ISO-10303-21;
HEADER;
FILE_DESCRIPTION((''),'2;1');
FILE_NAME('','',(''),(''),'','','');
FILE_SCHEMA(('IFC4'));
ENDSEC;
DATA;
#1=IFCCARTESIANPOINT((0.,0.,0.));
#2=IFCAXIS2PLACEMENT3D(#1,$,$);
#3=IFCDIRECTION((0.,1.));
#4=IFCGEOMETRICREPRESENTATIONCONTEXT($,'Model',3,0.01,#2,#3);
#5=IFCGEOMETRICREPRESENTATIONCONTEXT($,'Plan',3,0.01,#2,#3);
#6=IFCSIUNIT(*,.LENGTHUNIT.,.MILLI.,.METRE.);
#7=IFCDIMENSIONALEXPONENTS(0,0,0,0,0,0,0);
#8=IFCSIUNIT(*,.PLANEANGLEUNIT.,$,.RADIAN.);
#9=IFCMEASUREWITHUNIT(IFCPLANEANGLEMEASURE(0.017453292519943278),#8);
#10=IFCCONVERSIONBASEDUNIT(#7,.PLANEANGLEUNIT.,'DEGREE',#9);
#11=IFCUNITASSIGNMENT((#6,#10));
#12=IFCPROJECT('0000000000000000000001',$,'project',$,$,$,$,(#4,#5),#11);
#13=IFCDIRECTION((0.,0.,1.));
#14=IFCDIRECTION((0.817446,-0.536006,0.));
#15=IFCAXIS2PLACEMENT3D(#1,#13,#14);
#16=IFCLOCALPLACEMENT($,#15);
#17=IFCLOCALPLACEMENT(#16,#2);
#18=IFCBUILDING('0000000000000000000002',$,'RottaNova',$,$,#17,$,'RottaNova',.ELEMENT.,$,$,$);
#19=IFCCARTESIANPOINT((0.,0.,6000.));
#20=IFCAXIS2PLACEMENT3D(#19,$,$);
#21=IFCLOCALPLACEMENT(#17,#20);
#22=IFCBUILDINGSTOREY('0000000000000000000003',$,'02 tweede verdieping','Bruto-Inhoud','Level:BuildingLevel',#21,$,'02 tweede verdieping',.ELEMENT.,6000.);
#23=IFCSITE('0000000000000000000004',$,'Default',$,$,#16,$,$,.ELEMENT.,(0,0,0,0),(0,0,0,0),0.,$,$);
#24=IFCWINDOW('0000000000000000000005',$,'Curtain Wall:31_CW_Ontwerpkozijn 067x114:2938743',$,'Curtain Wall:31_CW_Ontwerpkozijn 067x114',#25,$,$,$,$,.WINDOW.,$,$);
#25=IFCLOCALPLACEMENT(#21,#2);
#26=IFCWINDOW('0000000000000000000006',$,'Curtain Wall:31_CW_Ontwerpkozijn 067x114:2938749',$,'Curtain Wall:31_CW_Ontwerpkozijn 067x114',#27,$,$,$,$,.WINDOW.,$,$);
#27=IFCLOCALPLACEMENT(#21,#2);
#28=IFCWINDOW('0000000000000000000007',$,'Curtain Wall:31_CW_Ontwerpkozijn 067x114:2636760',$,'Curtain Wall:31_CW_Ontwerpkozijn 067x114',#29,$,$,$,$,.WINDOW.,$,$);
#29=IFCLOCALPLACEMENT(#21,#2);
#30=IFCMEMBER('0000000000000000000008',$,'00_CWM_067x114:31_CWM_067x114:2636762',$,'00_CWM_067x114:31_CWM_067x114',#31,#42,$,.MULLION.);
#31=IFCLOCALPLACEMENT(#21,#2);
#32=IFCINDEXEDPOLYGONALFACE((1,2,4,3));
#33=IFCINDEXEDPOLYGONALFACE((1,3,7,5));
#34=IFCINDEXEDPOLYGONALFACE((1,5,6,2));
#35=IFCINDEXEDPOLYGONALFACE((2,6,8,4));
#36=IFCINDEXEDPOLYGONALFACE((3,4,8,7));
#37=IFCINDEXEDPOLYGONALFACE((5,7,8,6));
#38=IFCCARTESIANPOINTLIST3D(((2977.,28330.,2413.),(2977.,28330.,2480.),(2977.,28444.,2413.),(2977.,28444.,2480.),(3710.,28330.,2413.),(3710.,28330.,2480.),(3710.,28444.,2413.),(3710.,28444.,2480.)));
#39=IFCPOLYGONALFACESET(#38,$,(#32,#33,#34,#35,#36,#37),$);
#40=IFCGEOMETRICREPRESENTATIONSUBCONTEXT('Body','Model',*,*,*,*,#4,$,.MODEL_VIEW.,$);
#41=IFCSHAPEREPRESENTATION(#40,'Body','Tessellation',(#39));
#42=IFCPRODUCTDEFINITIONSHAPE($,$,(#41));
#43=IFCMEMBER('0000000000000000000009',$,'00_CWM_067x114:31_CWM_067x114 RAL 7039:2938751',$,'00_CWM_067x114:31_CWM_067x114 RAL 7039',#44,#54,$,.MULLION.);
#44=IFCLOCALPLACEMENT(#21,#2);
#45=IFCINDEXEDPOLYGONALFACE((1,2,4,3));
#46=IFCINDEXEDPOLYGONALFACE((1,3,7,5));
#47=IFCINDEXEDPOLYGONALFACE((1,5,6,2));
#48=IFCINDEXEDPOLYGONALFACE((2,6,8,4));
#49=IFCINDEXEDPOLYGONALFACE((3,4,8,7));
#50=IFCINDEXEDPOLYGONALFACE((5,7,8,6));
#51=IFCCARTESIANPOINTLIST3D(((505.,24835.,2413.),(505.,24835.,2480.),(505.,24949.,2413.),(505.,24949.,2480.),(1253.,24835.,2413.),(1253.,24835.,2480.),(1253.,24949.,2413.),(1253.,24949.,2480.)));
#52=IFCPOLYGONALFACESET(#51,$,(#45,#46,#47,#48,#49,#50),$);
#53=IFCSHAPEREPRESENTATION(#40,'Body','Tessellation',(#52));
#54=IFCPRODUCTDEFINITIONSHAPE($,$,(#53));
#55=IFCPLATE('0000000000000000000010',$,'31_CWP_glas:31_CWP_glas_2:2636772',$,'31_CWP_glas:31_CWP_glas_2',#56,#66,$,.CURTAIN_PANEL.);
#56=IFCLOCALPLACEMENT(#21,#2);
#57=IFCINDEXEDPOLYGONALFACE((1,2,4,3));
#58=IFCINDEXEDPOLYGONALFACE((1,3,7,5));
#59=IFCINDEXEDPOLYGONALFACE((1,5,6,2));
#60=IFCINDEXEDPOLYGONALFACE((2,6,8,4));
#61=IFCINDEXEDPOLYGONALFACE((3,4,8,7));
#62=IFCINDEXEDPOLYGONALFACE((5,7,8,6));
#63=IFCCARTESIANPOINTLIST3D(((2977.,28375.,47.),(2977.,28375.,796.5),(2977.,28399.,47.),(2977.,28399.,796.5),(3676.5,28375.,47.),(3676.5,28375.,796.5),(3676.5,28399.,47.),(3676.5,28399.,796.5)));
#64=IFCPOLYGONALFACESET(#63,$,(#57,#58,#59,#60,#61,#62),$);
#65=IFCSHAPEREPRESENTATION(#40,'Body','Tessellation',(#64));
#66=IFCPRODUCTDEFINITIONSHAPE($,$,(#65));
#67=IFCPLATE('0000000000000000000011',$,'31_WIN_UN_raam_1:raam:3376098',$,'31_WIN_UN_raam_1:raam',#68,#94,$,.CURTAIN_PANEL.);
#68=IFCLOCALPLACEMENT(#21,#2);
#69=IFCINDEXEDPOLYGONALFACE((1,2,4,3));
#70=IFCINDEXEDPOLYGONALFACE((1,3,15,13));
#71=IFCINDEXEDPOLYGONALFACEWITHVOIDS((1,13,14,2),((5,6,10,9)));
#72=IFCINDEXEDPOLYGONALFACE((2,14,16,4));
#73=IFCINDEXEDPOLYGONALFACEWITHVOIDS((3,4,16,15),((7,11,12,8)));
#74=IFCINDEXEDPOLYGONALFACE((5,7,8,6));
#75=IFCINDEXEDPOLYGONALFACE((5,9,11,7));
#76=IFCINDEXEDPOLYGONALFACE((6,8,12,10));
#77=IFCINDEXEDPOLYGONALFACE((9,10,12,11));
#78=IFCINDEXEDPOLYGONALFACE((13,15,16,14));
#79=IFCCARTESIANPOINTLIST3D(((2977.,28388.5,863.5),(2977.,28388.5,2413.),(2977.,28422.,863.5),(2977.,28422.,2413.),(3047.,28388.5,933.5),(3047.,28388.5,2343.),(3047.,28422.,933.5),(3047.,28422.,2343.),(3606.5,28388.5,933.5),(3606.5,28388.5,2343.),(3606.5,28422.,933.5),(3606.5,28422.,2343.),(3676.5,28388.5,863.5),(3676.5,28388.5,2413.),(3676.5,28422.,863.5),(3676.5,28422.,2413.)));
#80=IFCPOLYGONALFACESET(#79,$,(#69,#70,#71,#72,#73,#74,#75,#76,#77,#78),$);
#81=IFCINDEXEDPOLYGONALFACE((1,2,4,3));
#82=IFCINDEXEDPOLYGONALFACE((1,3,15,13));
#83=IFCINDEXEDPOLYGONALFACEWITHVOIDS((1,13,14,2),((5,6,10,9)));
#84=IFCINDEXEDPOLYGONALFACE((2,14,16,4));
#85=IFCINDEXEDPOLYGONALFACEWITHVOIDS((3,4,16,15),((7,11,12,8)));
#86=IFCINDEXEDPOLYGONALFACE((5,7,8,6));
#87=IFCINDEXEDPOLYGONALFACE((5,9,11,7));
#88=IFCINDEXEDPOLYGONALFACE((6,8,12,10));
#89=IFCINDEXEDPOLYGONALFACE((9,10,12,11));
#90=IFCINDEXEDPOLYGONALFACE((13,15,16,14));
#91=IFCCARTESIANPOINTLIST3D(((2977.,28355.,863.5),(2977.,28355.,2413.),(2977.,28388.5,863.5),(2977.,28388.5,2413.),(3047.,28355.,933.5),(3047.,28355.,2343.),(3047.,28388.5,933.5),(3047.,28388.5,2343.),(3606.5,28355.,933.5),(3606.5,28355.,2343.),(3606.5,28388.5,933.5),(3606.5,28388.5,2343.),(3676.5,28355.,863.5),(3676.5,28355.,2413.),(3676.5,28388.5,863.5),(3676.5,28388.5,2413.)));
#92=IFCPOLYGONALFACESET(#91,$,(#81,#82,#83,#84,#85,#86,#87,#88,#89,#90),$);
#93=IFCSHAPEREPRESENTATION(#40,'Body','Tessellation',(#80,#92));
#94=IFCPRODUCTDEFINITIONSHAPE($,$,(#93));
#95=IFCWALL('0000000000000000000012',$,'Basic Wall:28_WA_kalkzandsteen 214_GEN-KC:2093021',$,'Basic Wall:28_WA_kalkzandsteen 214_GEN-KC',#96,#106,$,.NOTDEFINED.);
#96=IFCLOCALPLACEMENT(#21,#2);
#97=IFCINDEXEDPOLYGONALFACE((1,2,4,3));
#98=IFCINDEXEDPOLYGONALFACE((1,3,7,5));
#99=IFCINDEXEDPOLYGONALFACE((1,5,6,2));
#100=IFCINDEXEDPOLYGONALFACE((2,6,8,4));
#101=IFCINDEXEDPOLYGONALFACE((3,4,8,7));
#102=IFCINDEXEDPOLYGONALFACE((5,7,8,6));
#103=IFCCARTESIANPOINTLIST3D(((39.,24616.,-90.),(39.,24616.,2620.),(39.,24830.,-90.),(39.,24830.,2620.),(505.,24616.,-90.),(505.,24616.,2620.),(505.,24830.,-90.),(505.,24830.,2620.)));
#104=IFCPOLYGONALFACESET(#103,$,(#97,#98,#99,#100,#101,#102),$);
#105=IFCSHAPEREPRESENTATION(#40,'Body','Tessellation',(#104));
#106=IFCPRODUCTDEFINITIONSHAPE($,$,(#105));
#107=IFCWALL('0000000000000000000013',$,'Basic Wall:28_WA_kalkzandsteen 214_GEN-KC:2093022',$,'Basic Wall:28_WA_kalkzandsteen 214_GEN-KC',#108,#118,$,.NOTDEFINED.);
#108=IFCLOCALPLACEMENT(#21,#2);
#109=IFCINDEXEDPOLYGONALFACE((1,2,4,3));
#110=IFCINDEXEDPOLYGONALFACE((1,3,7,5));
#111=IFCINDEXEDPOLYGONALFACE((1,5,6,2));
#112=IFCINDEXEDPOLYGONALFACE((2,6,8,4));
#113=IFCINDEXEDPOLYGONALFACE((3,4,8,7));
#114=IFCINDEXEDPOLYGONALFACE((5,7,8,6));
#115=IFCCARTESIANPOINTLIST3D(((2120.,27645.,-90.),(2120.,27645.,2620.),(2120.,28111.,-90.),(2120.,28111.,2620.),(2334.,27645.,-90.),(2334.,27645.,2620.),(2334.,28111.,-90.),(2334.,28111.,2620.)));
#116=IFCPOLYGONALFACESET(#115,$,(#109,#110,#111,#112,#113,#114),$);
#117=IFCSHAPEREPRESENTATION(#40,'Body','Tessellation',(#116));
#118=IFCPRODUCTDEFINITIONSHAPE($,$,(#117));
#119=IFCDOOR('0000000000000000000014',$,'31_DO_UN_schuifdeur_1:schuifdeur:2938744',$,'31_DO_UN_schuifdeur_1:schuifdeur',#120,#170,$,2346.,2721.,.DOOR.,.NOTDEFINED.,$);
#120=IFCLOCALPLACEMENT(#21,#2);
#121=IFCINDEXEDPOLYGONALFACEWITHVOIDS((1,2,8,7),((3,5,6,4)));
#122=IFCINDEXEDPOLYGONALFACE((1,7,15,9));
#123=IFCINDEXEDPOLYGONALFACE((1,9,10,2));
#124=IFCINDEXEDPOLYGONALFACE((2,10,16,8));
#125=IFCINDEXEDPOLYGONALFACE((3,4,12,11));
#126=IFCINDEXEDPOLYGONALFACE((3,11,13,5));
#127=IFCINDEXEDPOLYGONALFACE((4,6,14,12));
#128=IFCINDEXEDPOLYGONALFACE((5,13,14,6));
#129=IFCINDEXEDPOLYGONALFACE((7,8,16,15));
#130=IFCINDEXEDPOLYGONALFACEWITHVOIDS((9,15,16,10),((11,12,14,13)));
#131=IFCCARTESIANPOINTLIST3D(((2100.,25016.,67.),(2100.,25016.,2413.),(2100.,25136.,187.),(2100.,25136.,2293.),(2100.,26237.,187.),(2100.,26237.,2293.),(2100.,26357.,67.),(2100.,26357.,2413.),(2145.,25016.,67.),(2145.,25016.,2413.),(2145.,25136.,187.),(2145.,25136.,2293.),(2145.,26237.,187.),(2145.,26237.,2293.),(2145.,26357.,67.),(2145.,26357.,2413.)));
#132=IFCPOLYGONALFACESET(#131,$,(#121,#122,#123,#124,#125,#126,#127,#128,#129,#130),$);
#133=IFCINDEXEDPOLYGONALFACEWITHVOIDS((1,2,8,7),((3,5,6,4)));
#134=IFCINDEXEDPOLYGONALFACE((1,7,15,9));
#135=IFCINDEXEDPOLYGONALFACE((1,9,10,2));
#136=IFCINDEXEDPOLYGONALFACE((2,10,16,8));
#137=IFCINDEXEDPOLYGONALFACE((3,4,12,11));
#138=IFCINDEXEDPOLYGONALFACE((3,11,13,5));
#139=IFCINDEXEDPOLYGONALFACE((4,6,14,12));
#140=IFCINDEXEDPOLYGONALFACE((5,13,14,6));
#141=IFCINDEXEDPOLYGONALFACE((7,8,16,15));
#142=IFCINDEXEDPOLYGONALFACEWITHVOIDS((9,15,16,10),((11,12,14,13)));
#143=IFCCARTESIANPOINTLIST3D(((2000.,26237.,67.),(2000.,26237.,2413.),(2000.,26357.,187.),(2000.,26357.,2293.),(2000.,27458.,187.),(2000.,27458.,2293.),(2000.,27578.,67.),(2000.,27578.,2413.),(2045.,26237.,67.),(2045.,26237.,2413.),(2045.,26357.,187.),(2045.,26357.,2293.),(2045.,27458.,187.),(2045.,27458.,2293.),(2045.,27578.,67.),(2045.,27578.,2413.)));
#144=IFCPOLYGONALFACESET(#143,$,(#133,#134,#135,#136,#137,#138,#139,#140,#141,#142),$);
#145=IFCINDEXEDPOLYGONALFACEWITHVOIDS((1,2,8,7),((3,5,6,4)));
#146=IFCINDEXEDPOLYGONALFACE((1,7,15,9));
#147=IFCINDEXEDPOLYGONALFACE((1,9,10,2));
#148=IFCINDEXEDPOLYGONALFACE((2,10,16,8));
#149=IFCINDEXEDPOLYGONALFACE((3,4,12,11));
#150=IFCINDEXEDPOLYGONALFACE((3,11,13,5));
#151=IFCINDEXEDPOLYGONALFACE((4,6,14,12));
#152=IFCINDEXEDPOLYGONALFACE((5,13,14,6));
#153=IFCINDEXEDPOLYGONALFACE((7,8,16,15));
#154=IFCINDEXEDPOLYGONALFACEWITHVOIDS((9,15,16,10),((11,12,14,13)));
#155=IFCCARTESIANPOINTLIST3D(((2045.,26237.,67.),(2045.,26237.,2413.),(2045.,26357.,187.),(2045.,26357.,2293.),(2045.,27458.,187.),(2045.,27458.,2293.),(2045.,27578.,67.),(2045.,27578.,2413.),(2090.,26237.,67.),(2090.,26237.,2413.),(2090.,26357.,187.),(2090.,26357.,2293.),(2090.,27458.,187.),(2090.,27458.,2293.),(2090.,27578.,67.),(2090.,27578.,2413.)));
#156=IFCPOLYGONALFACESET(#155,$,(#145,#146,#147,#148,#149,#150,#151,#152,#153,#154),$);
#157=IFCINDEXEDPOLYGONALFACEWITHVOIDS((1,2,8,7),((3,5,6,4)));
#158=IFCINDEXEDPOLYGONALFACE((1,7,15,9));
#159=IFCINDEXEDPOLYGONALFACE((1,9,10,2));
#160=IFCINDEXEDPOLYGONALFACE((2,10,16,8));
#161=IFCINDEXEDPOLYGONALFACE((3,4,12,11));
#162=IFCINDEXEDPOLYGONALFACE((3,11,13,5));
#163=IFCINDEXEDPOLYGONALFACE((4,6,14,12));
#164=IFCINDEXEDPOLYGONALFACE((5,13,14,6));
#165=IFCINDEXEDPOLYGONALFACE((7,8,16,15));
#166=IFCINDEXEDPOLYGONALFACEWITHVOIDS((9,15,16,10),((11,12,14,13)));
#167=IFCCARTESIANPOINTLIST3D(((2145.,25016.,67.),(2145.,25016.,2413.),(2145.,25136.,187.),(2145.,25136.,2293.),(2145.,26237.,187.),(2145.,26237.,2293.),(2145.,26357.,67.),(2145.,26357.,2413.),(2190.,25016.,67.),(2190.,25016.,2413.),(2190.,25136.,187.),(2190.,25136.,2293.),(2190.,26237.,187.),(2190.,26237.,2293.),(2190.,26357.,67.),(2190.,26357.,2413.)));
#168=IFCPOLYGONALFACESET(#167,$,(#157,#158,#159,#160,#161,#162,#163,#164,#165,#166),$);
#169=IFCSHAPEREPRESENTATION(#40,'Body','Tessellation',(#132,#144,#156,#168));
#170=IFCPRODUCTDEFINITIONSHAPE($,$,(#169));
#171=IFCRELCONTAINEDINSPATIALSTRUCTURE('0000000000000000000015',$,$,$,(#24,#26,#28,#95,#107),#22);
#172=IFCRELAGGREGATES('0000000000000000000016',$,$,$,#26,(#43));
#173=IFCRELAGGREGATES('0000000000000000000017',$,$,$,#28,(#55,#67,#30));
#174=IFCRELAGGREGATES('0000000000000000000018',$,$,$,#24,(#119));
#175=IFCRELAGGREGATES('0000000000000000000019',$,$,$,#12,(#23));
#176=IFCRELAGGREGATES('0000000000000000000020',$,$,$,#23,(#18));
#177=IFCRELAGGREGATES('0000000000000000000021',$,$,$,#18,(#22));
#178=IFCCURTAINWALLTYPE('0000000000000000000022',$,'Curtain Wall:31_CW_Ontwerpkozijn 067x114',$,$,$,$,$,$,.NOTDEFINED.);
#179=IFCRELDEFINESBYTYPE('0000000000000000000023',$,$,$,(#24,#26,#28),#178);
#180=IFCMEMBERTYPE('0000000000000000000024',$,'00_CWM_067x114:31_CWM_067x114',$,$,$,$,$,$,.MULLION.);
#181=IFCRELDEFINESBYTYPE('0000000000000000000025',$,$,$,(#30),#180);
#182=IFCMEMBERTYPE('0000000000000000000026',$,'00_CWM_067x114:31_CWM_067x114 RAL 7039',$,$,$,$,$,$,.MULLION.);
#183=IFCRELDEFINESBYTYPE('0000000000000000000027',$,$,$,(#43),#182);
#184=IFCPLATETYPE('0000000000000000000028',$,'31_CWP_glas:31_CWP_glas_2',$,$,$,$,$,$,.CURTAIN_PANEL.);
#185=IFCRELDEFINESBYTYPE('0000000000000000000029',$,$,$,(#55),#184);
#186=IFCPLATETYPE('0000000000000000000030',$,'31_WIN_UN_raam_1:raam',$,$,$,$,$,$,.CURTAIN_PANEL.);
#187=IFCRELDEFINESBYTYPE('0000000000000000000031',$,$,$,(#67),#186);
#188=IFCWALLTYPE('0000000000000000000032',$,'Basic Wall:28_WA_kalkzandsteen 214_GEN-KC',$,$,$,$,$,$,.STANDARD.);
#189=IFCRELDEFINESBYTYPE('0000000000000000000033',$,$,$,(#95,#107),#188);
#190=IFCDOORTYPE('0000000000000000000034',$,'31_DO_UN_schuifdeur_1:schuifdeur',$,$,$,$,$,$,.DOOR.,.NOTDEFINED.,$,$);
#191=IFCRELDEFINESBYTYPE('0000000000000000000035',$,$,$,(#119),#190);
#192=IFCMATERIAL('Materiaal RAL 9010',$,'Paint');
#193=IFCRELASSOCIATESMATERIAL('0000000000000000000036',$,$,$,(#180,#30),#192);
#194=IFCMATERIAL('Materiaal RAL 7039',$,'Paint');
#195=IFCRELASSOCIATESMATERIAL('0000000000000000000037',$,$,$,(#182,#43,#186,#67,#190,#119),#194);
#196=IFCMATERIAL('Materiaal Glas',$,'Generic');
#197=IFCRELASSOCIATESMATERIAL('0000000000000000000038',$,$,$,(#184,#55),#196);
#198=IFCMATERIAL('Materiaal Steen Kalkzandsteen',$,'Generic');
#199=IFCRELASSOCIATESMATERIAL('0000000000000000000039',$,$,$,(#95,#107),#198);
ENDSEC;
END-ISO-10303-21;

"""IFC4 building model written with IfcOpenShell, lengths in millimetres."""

from ifc_helpers import new_model, entity, si_unit, converted_unit, direction, frame, origin, place, context, subcontext, project, spatial, indexed_curve, outline, extrude, source, transform, mapped, material, type_object, type_shapes, element, aggregate, save


model = new_model("IFC4")

# Units and contexts
model_context = context("Model", 3, precision=0.01, world=origin(), true_north=direction((0.0, 1.0)))
plan_context = context("Plan", 3, precision=0.01, world=origin(), true_north=direction((0.0, 1.0)))
body_context = subcontext(model_context, "Body", "Model", "MODEL_VIEW")
ifc_project = project(units=[si_unit("LENGTHUNIT", "METRE", prefix="MILLI"), converted_unit("PLANEANGLEUNIT", "DEGREE", entity("IfcPlaneAngleMeasure", 0.017453292519943278), si_unit("PLANEANGLEUNIT", "RADIAN"), dimensions=[0, 0, 0, 0, 0, 0, 0])], contexts=[model_context, plan_context])

# Site, building, storey
site_placement = place(None, frame((0.0, 0.0, 0.0), z_axis=(0.0, 0.0, 1.0), x_axis=(0.817446, -0.536006, 0.0)))
site = spatial("IfcSite", under=ifc_project, at=site_placement, Name="Default", CompositionType="ELEMENT", RefLatitude=(0, 0, 0, 0), RefLongitude=(0, 0, 0, 0), RefElevation=0.0)
building_placement = place(site_placement, origin())
building = spatial("IfcBuilding", under=site, at=building_placement, Name="RottaNova", LongName="RottaNova", CompositionType="ELEMENT")
storey_placement = place(building_placement, frame((0.0, 0.0, 6000.0)))
storey = spatial("IfcBuildingStorey", under=building, at=storey_placement, Name="02 tweede verdieping", Description="Bruto-Inhoud", ObjectType="Level:BuildingLevel", LongName="02 tweede verdieping", CompositionType="ELEMENT", Elevation=6000.0)

# Window
curtain_wall_type = type_object("IfcCurtainWallType", Name="Curtain Wall:31_CW_Ontwerpkozijn 067x114", PredefinedType="NOTDEFINED")
window_1_placement = place(storey_placement, frame((0.0, 0.0, -6000.0)))
window_1 = element("IfcWindow", 1, at=window_1_placement, inside=storey, type_object=curtain_wall_type, Name="Curtain Wall:31_CW_Ontwerpkozijn 067x114:2938743", ObjectType="Curtain Wall:31_CW_Ontwerpkozijn 067x114", PredefinedType="WINDOW")
ifc_material_1 = material(Name="Materiaal RAL 7039", Category="Paint")

# Window
window_2_placement = place(storey_placement, frame((0.0, 0.0, -6000.0)))
window_2 = element("IfcWindow", 2, at=window_2_placement, inside=storey, type_object=curtain_wall_type, Name="Curtain Wall:31_CW_Ontwerpkozijn 067x114:2938749", ObjectType="Curtain Wall:31_CW_Ontwerpkozijn 067x114", PredefinedType="WINDOW")

# Window, member
window_3_placement = place(storey_placement, frame((0.0, 0.0, -6000.0)))
window_3 = element("IfcWindow", 3, at=window_3_placement, inside=storey, type_object=curtain_wall_type, Name="Curtain Wall:31_CW_Ontwerpkozijn 067x114:2636760", ObjectType="Curtain Wall:31_CW_Ontwerpkozijn 067x114", PredefinedType="WINDOW")
ifc_material_2 = material(Name="Materiaal RAL 9010", Category="Paint")
member_type_1 = type_object("IfcMemberType", Name="00_CWM_067x114:31_CWM_067x114", PredefinedType="MULLION", material=ifc_material_2)
shared_shape_1 = source(origin(), body_context, "Body", "SweptSolid", [
    extrude(outline(indexed_curve([(-33.5, -57.0), (33.5, -57.0), (33.5, 57.0), (-33.5, 57.0), (-33.5, -57.0)], self_intersect=False)), frame((-33.5, 57.0, -733.0), z_axis=(0.0, 0.0, 1.0), x_axis=(-1.0, 0.0, 0.0)), (0.0, 0.0, 1.0), 733.0),
])
type_shapes(member_type_1, [shared_shape_1])
member_1_placement = place(window_3_placement, frame((2977.0, 28330.0, 8480.0), z_axis=(-1.0, 0.0, 0.0), x_axis=(0.0, 0.0, 1.0)))
member_1 = element("IfcMember", 4, at=member_1_placement, type_object=member_type_1, material=ifc_material_2, Name="00_CWM_067x114:31_CWM_067x114:2636762", ObjectType="00_CWM_067x114:31_CWM_067x114", PredefinedType="MULLION", context=body_context, shape_type="MappedRepresentation", body=[
    mapped(shared_shape_1, transform((0.0, 0.0, 0.0), scale=1.0)),
])

# Member
member_type_2 = type_object("IfcMemberType", Name="00_CWM_067x114:31_CWM_067x114 RAL 7039", PredefinedType="MULLION", material=ifc_material_1)
shared_shape_2 = source(origin(), body_context, "Body", "SweptSolid", [
    extrude(outline(indexed_curve([(-33.5, -57.0), (33.5, -57.0), (33.5, 57.0), (-33.5, 57.0), (-33.5, -57.0)], self_intersect=False)), frame((-33.5, 57.0, -748.0), z_axis=(0.0, 0.0, 1.0), x_axis=(-1.0, 0.0, 0.0)), (0.0, 0.0, 1.0), 748.0),
])
type_shapes(member_type_2, [shared_shape_2])
member_2_placement = place(window_2_placement, frame((505.0, 24835.0, 8480.0), z_axis=(-1.0, 0.0, 0.0), x_axis=(0.0, 0.0, 1.0)))
member_2 = element("IfcMember", 5, at=member_2_placement, type_object=member_type_2, material=ifc_material_1, Name="00_CWM_067x114:31_CWM_067x114 RAL 7039:2938751", ObjectType="00_CWM_067x114:31_CWM_067x114 RAL 7039", PredefinedType="MULLION", context=body_context, shape_type="MappedRepresentation", body=[
    mapped(shared_shape_2, transform((0.0, 0.0, 0.0), scale=1.0)),
])
aggregate(window_2, [member_2])

# Plates
ifc_material_3 = material(Name="Materiaal Glas", Category="Generic")
plate_type_1 = type_object("IfcPlateType", Name="31_CWP_glas:31_CWP_glas_2", PredefinedType="CURTAIN_PANEL", material=ifc_material_3)
shared_shape_3 = source(origin(), body_context, "Body", "SweptSolid", [
    extrude(outline(indexed_curve([(-12.0, -349.7), (12.0, -349.7), (12.0, 349.7), (-12.0, 349.7), (-12.0, -349.7)], self_intersect=False)), frame((0.0, -57.0, 0.0), z_axis=(0.0, 0.0, 1.0), x_axis=(0.0, 1.0, 0.0)), (0.0, 0.0, 1.0), 749.5),
])
type_shapes(plate_type_1, [shared_shape_3])
plate_1_placement = place(window_3_placement, frame((3326.7, 28330.0, 6047.0), z_axis=(0.0, 0.0, 1.0), x_axis=(-1.0, 0.0, 0.0)))
plate_1 = element("IfcPlate", 6, at=plate_1_placement, type_object=plate_type_1, material=ifc_material_3, Name="31_CWP_glas:31_CWP_glas_2:2636772", ObjectType="31_CWP_glas:31_CWP_glas_2", PredefinedType="CURTAIN_PANEL", context=body_context, shape_type="MappedRepresentation", body=[
    mapped(shared_shape_3, transform((0.0, 0.0, 0.0), scale=1.0)),
])
plate_type_2 = type_object("IfcPlateType", Name="31_WIN_UN_raam_1:raam", PredefinedType="CURTAIN_PANEL", material=ifc_material_1)
shared_shape_4 = source(origin(), body_context, "Body", "SweptSolid", [
    extrude(outline(indexed_curve([(-349.8, -774.7), (349.8, -774.7), (349.8, 774.7), (-349.8, 774.7), (-349.8, -774.7)], self_intersect=False), holes=[indexed_curve([(-279.8, 704.7), (279.8, 704.7), (279.8, -704.8), (-279.8, -704.8), (-279.8, 704.7)], self_intersect=False)]), frame((0.0, -92.0, 774.8), z_axis=(0.0, 1.0, 0.0), x_axis=(1.0, 0.0, 0.0)), (0.0, 0.0, 1.0), 33.5),
    extrude(outline(indexed_curve([(-349.8, -774.7), (349.8, -774.7), (349.8, 774.7), (-349.8, 774.7), (-349.8, -774.7)], self_intersect=False), holes=[indexed_curve([(-279.8, 704.7), (279.8, 704.7), (279.8, -704.8), (-279.8, -704.8), (-279.8, 704.7)], self_intersect=False)]), frame((0.0, -58.5, 774.8), z_axis=(0.0, 1.0, 0.0), x_axis=(1.0, 0.0, 0.0)), (0.0, 0.0, 1.0), 33.5),
])
type_shapes(plate_type_2, [shared_shape_4])
plate_2_placement = place(window_3_placement, frame((3326.7, 28330.0, 6863.5), z_axis=(0.0, 0.0, 1.0), x_axis=(-1.0, 0.0, 0.0)))
plate_2 = element("IfcPlate", 7, at=plate_2_placement, type_object=plate_type_2, material=ifc_material_1, Name="31_WIN_UN_raam_1:raam:3376098", ObjectType="31_WIN_UN_raam_1:raam", PredefinedType="CURTAIN_PANEL", context=body_context, shape_type="MappedRepresentation", body=[
    mapped(shared_shape_4, transform((0.0, 0.0, 0.0), scale=1.0)),
])
aggregate(window_3, [plate_1, plate_2, member_1])

# Walls
ifc_material_4 = material(Name="Materiaal Steen Kalkzandsteen", Category="Generic")
wall_type_1 = type_object("IfcWallType", Name="Basic Wall:28_WA_kalkzandsteen 214_GEN-KC", PredefinedType="STANDARD")
wall_1_placement = place(storey_placement, frame((39.0, 24723.0, -90.0)))
element("IfcWall", 8, at=wall_1_placement, inside=storey, type_object=wall_type_1, material=ifc_material_4, Name="Basic Wall:28_WA_kalkzandsteen 214_GEN-KC:2093021", ObjectType="Basic Wall:28_WA_kalkzandsteen 214_GEN-KC", PredefinedType="NOTDEFINED", context=body_context, shape_type="SweptSolid", body=[
    extrude(outline(indexed_curve([(466.0, 107.0), (0.0, 107.0), (0.0, -107.0), (466.0, -107.0), (466.0, 107.0)], self_intersect=False)), origin(), (0.0, 0.0, 1.0), 2710.0),
])
wall_2_placement = place(storey_placement, frame((2227.0, 28111.0, -90.0), z_axis=(0.0, 0.0, 1.0), x_axis=(0.0, -1.0, 0.0)))
element("IfcWall", 9, at=wall_2_placement, inside=storey, type_object=wall_type_1, material=ifc_material_4, Name="Basic Wall:28_WA_kalkzandsteen 214_GEN-KC:2093022", ObjectType="Basic Wall:28_WA_kalkzandsteen 214_GEN-KC", PredefinedType="NOTDEFINED", context=body_context, shape_type="SweptSolid", body=[
    extrude(outline(indexed_curve([(466.0, 107.0), (0.0, 107.0), (0.0, -107.0), (466.0, -107.0), (466.0, 107.0)], self_intersect=False)), origin(), (0.0, 0.0, 1.0), 2710.0),
])

# Door
door_type = type_object("IfcDoorType", Name="31_DO_UN_schuifdeur_1:schuifdeur", OperationType="NOTDEFINED", PredefinedType="DOOR", material=ifc_material_1)
shared_shape_5 = source(origin(), body_context, "Body", "SweptSolid", [
    extrude(outline(indexed_curve([(-670.5, -1173.0), (670.5, -1173.0), (670.5, 1173.0), (-670.5, 1173.0), (-670.5, -1173.0)], self_intersect=False), holes=[indexed_curve([(-550.5, -1053.0), (-550.5, 1053.0), (550.5, 1053.0), (550.5, -1053.0), (-550.5, -1053.0)], self_intersect=False)]), frame((-610.5, 90.0, 1173.0), z_axis=(0.0, -1.0, 0.0), x_axis=(-1.0, 0.0, 0.0)), (0.0, 0.0, 1.0), 45.0),
    extrude(outline(indexed_curve([(-670.5, -1173.0), (670.5, -1173.0), (670.5, 1173.0), (-670.5, 1173.0), (-670.5, -1173.0)], self_intersect=False), holes=[indexed_curve([(-550.5, -1053.0), (-550.5, 1053.0), (550.5, 1053.0), (550.5, -1053.0), (-550.5, -1053.0)], self_intersect=False)]), frame((610.5, 190.0, 1173.0), z_axis=(0.0, -1.0, 0.0), x_axis=(-1.0, 0.0, 0.0)), (0.0, 0.0, 1.0), 45.0),
    extrude(outline(indexed_curve([(-670.5, -1173.0), (670.5, -1173.0), (670.5, 1173.0), (-670.5, 1173.0), (-670.5, -1173.0)], self_intersect=False), holes=[indexed_curve([(-550.5, -1053.0), (-550.5, 1053.0), (550.5, 1053.0), (550.5, -1053.0), (-550.5, -1053.0)], self_intersect=False)]), frame((610.5, 145.0, 1173.0), z_axis=(0.0, -1.0, 0.0), x_axis=(-1.0, 0.0, 0.0)), (0.0, 0.0, 1.0), 45.0),
    extrude(outline(indexed_curve([(-670.5, -1173.0), (670.5, -1173.0), (670.5, 1173.0), (-670.5, 1173.0), (-670.5, -1173.0)], self_intersect=False), holes=[indexed_curve([(-550.5, -1053.0), (-550.5, 1053.0), (550.5, 1053.0), (550.5, -1053.0), (-550.5, -1053.0)], self_intersect=False)]), frame((-610.5, 45.0, 1173.0), z_axis=(0.0, -1.0, 0.0), x_axis=(-1.0, 0.0, 0.0)), (0.0, 0.0, 1.0), 45.0),
])
type_shapes(door_type, [shared_shape_5])
door_placement = place(window_1_placement, frame((2190.0, 26297.0, 6067.0), z_axis=(0.0, 0.0, 1.0), x_axis=(0.0, 1.0, 0.0)))
door = element("IfcDoor", 10, at=door_placement, type_object=door_type, material=ifc_material_1, Name="31_DO_UN_schuifdeur_1:schuifdeur:2938744", ObjectType="31_DO_UN_schuifdeur_1:schuifdeur", OperationType="NOTDEFINED", OverallHeight=2346.0, OverallWidth=2721.0, PredefinedType="DOOR", context=body_context, shape_type="MappedRepresentation", body=[
    mapped(shared_shape_5, transform((0.0, 0.0, 0.0), scale=1.0)),
])
aggregate(window_1, [door])

save(model, "model.ifc")
